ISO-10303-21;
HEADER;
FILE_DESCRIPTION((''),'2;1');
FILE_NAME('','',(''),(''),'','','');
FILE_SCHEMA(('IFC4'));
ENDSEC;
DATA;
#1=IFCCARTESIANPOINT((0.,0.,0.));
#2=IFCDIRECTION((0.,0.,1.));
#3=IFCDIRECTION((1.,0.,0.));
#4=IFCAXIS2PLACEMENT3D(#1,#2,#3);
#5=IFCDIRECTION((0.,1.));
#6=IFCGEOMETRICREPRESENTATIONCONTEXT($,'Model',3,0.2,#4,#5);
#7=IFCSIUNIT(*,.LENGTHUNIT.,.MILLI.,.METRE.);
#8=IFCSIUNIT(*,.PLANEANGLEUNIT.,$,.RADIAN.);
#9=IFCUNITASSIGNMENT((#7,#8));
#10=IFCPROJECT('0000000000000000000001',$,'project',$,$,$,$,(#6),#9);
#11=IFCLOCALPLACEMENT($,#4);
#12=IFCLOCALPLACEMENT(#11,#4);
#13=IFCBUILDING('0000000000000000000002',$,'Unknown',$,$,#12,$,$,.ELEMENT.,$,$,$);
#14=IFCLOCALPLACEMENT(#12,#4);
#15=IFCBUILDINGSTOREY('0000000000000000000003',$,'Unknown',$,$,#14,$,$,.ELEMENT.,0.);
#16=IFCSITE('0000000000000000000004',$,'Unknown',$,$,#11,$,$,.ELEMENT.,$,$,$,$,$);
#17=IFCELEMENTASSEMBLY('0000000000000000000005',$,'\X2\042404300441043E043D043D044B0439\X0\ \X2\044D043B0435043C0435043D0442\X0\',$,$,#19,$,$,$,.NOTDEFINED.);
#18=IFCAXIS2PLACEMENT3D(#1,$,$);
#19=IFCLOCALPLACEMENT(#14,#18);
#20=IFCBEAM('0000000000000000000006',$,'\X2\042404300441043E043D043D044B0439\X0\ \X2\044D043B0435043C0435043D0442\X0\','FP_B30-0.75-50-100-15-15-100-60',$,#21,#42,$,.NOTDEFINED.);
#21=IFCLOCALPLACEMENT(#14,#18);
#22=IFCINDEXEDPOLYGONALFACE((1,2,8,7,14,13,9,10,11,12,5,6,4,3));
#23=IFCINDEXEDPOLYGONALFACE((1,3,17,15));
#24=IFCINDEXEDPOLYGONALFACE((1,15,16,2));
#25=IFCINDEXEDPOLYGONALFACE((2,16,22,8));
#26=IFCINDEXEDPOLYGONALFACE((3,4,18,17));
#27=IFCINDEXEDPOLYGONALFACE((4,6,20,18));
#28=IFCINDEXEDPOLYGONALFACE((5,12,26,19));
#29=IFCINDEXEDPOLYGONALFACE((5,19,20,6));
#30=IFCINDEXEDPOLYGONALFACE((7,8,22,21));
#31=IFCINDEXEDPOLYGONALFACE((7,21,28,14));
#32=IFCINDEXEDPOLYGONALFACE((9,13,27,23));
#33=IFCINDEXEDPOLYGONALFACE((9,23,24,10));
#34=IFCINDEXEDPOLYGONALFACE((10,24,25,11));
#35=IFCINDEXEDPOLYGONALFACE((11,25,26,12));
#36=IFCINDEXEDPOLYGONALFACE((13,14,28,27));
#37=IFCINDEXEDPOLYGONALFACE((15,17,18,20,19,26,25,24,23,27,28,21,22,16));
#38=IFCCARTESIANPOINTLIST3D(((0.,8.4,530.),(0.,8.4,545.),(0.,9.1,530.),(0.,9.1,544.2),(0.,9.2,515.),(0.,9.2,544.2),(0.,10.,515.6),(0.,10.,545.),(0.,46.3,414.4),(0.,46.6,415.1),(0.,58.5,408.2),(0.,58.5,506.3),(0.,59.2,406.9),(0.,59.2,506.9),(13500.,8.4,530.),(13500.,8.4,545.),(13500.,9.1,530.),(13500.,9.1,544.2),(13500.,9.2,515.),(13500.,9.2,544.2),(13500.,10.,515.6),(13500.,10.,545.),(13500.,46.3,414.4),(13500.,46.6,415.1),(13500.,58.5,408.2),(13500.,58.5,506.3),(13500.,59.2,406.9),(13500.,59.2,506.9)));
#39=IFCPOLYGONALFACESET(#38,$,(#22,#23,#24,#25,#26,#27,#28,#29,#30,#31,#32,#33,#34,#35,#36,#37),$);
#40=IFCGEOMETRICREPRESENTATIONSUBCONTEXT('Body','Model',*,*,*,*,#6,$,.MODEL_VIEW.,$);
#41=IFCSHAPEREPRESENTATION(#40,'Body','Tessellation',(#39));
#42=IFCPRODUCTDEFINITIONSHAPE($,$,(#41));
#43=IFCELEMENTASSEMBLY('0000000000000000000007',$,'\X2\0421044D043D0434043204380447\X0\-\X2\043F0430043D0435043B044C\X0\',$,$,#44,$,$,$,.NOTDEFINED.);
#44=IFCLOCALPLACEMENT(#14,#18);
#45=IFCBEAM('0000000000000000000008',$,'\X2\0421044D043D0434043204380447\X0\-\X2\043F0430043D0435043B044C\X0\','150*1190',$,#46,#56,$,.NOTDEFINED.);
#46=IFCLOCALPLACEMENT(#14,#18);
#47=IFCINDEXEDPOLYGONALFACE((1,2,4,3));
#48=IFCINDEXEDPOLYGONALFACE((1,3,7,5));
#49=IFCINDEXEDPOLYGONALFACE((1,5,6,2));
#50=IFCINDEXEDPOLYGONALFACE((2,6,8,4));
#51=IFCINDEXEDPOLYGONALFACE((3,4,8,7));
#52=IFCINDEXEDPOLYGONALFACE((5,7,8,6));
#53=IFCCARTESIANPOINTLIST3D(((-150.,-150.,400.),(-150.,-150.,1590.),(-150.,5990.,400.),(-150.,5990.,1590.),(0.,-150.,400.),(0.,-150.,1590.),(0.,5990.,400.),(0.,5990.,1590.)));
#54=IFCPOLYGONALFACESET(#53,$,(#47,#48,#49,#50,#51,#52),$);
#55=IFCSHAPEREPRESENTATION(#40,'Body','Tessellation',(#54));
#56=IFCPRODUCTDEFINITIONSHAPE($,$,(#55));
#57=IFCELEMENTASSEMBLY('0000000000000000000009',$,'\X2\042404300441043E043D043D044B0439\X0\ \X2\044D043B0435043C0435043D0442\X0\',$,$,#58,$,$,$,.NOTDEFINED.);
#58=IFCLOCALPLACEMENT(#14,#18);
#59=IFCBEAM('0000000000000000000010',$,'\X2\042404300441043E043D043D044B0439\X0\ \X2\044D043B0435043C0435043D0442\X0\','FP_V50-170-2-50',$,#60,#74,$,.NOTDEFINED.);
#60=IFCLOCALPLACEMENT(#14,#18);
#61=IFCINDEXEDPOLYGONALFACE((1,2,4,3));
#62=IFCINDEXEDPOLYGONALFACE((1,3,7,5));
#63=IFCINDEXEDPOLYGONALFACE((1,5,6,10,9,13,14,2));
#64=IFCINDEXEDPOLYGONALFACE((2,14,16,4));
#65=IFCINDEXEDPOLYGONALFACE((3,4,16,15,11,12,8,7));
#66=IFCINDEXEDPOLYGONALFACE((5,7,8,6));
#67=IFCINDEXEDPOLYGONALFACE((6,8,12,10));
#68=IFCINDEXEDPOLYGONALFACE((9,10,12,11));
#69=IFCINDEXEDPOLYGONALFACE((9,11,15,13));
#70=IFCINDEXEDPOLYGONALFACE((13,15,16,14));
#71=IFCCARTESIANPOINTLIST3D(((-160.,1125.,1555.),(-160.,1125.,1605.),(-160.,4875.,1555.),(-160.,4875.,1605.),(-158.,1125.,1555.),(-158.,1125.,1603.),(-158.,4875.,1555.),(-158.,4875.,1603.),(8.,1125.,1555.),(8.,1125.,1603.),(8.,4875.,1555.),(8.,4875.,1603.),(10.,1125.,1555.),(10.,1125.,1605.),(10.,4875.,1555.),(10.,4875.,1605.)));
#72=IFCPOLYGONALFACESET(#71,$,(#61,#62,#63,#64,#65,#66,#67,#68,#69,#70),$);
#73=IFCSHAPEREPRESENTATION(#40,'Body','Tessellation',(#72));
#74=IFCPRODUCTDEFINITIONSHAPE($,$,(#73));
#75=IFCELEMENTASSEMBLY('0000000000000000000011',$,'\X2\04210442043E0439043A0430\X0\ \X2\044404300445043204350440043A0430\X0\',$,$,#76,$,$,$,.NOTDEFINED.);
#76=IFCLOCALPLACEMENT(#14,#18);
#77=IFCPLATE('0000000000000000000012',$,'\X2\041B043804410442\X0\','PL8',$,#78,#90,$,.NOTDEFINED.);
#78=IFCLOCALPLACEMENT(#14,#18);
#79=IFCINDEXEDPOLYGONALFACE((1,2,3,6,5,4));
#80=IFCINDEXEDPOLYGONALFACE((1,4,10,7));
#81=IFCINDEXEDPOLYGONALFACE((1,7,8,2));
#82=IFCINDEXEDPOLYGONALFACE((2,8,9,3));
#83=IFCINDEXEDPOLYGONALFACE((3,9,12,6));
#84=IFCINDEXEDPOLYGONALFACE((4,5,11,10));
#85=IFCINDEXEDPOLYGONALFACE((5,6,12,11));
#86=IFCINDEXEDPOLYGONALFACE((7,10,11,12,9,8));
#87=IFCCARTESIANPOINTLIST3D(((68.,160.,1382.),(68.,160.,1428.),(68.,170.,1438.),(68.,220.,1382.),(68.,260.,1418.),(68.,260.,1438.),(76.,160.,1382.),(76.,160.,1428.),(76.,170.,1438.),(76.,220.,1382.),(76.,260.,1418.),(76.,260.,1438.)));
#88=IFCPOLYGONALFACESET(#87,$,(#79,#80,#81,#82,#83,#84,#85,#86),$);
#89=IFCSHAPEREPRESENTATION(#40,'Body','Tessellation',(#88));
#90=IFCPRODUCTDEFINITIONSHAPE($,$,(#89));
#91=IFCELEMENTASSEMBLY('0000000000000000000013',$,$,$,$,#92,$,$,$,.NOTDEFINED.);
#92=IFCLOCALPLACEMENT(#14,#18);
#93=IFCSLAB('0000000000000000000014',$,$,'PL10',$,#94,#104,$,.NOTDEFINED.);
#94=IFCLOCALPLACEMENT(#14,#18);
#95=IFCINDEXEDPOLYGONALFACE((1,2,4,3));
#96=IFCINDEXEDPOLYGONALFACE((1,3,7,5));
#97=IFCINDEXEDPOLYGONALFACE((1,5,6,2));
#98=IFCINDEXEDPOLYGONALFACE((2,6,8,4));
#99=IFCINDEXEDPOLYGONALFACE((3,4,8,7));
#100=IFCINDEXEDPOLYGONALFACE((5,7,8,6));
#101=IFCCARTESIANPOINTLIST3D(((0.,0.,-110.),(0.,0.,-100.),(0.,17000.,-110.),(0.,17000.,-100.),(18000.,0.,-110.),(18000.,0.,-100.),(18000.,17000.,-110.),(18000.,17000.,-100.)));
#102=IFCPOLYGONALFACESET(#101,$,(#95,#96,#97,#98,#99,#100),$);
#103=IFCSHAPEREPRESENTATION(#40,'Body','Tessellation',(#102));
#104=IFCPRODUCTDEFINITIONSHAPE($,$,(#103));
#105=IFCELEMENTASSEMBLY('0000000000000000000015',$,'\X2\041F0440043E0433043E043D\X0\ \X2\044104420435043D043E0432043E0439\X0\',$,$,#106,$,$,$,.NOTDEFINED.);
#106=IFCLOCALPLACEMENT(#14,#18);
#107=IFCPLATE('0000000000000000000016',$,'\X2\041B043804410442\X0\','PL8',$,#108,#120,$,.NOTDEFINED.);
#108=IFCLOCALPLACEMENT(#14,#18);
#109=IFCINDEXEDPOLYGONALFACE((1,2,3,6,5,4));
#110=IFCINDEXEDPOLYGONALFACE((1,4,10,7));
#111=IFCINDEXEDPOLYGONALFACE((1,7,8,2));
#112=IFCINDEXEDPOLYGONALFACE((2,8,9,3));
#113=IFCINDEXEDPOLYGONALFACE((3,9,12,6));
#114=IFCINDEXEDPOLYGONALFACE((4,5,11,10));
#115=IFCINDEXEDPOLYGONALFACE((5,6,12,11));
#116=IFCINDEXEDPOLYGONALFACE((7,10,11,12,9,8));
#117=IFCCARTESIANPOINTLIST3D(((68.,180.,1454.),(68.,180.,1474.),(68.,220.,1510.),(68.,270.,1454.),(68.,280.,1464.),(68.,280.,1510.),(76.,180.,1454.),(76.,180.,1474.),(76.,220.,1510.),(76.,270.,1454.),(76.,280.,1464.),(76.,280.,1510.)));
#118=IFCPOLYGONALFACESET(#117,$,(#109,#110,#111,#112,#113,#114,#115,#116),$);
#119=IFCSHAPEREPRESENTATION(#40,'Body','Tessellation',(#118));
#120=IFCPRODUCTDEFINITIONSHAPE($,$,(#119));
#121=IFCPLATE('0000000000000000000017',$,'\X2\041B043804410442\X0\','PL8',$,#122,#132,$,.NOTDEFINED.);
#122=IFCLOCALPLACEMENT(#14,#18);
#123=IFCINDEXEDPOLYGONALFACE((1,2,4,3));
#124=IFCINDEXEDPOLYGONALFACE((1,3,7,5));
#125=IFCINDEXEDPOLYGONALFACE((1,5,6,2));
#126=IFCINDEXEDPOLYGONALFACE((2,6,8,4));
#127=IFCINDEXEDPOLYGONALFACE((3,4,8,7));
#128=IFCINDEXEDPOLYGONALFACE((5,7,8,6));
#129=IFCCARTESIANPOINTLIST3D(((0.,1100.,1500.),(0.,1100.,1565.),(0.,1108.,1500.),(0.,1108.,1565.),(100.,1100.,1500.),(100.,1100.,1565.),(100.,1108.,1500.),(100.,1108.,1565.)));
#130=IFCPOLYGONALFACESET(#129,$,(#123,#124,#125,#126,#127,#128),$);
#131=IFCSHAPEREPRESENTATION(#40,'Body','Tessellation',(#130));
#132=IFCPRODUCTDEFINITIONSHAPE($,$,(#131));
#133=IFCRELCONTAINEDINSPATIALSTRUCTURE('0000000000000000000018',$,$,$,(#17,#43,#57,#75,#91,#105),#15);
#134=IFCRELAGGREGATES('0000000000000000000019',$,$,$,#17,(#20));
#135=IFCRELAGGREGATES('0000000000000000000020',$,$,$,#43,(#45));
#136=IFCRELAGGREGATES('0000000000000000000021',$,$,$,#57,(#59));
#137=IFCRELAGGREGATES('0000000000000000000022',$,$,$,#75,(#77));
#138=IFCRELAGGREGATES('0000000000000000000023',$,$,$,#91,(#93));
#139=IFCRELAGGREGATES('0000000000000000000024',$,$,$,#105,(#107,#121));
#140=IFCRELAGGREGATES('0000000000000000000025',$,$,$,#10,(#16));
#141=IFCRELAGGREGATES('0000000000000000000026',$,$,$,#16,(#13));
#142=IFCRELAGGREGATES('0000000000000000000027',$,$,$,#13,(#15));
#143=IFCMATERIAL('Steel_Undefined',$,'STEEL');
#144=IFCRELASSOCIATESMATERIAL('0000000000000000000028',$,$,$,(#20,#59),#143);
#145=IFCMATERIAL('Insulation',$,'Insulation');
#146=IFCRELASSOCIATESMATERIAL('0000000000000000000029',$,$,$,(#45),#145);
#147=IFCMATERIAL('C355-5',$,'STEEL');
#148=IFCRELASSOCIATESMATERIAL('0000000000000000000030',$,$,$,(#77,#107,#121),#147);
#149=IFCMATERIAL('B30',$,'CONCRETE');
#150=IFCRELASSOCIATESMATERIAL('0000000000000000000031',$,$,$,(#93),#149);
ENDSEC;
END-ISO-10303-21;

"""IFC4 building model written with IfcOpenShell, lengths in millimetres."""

from ifc_helpers import new_model, si_unit, direction, frame, origin_with_axes, place, context, subcontext, project, spatial, line, indexed_curve, outline, extrude, material, element, aggregate, save


model = new_model("IFC4")

# Units and contexts
model_context = context("Model", 3, precision=0.2, world=origin_with_axes(), true_north=direction((0.0, 1.0)))
body_context = subcontext(model_context, "Body", "Model", "MODEL_VIEW")
ifc_project = project(units=[si_unit("LENGTHUNIT", "METRE", prefix="MILLI"), si_unit("PLANEANGLEUNIT", "RADIAN")], contexts=[model_context])

# Site, building, storey
site_placement = place(None, origin_with_axes())
site = spatial("IfcSite", under=ifc_project, at=site_placement, Name="Unknown", CompositionType="ELEMENT")
building_placement = place(site_placement, origin_with_axes())
building = spatial("IfcBuilding", under=site, at=building_placement, Name="Unknown", CompositionType="ELEMENT")
storey_placement = place(building_placement, origin_with_axes())
storey = spatial("IfcBuildingStorey", under=building, at=storey_placement, Name="Unknown", CompositionType="ELEMENT", Elevation=0.0)

# Shared definitions
ifc_material_1 = material(Name="Steel_Undefined", Category="STEEL")

# Shared definitions
ifc_material_2 = material(Name="C355-5", Category="STEEL")

# Element assemblies, beams
ifc_material_3 = material(Name="Insulation", Category="Insulation")
assembly_1_placement = place(storey_placement, frame((0.0, 9.6, 530.0), z_axis=(0.0, -1.0, 0.0), x_axis=(1.0, 0.0, 0.0)))
assembly_1 = element("IfcElementAssembly", 1, at=assembly_1_placement, inside=storey, Name="Фасонный элемент", PredefinedType="NOTDEFINED")
beam_1_placement = place(assembly_1_placement, origin_with_axes())
beam_1 = element("IfcBeam", 2, at=beam_1_placement, material=ifc_material_1, Name="Фасонный элемент", Description="FP_B30-0.75-50-100-15-15-100-60", PredefinedType="NOTDEFINED", context=body_context, shape_type="SolidModel", body=[
    extrude(outline(indexed_curve([(0.4, -15.0), (0.4, 14.2), (0.5, 14.2), (0.5, 0.0), (1.2, 0.0), (1.2, 15.0), (-0.4, 15.0), (-0.4, -14.4), (-49.6, -23.1), (-49.6, -123.1), (-36.6, -115.6), (-37.0, -114.9), (-48.9, -121.8), (-48.9, -23.7)], segments=[line(1, 2, 3, 4, 5, 6, 7, 8, 9, 10, 11, 12, 13, 14, 1)])), frame((0.0, 0.0, 0.0), z_axis=(-1.0, 0.0, 0.0), x_axis=(0.0, 0.0, 1.0)), (0.0, 0.0, -1.0), 13500.0),
])
aggregate(assembly_1, [beam_1])
assembly_2_placement = place(storey_placement, frame((-75.0, -150.0, 995.0), z_axis=(0.0, 0.0, -1.0), x_axis=(0.0, 1.0, 0.0)))
assembly_2 = element("IfcElementAssembly", 3, at=assembly_2_placement, inside=storey, Name="Сэндвич-панель", PredefinedType="NOTDEFINED")
beam_2_placement = place(assembly_2_placement, origin_with_axes())
beam_2 = element("IfcBeam", 4, at=beam_2_placement, material=ifc_material_3, Name="Сэндвич-панель", Description="150*1190", PredefinedType="NOTDEFINED", context=body_context, shape_type="SolidModel", body=[
    extrude(outline(indexed_curve([(-595.0, -75.0), (595.0, -75.0), (595.0, 75.0), (-595.0, 75.0)], segments=[line(1, 2, 3, 4, 1)])), frame((0.0, 0.0, 0.0), z_axis=(-1.0, 0.0, 0.0), x_axis=(0.0, 0.0, 1.0)), (0.0, 0.0, -1.0), 6140.0),
])
aggregate(assembly_2, [beam_2])
assembly_3_placement = place(storey_placement, frame((-75.0, 1125.0, 1580.0), z_axis=(1.0, 0.0, 0.0), x_axis=(0.0, 1.0, 0.0)))
assembly_3 = element("IfcElementAssembly", 5, at=assembly_3_placement, inside=storey, Name="Фасонный элемент", PredefinedType="NOTDEFINED")
beam_3_placement = place(assembly_3_placement, origin_with_axes())
beam_3 = element("IfcBeam", 6, at=beam_3_placement, material=ifc_material_1, Name="Фасонный элемент", Description="FP_V50-170-2-50", PredefinedType="NOTDEFINED", context=body_context, shape_type="SolidModel", body=[
    extrude(outline(indexed_curve([(-85.0, -25.0), (-83.0, -25.0), (-83.0, 23.0), (83.0, 23.0), (83.0, -25.0), (85.0, -25.0), (85.0, 25.0), (-85.0, 25.0)], segments=[line(1, 2, 3, 4, 5, 6, 7, 8, 1)])), frame((0.0, 0.0, 0.0), z_axis=(-1.0, 0.0, 0.0), x_axis=(0.0, 0.0, 1.0)), (0.0, 0.0, -1.0), 3750.0),
])
aggregate(assembly_3, [beam_3])

# Element assembly, plate
assembly_4_placement = place(storey_placement, frame((80.0, 80.0, -200.0), z_axis=(0.0, -1.0, 0.0), x_axis=(0.0, 0.0, 1.0)))
assembly_4 = element("IfcElementAssembly", 7, at=assembly_4_placement, inside=storey, Name="Стойка фахверка", PredefinedType="NOTDEFINED")
plate_1_placement = place(assembly_4_placement, frame((1638.0, 8.0, -90.0), z_axis=(0.0, 1.0, 0.0), x_axis=(0.0, 0.0, -1.0)))
plate_1 = element("IfcPlate", 8, at=plate_1_placement, material=ifc_material_2, Name="Лист", Description="PL8", PredefinedType="NOTDEFINED", context=body_context, shape_type="SolidModel", body=[
    extrude(outline(indexed_curve([(0.0, 0.0), (90.0, 0.0), (90.0, 20.0), (50.0, 56.0), (-10.0, 56.0), (-10.0, 10.0)], segments=[line(1, 2, 3, 4, 5, 6, 1)])), frame((0.0, 0.0, 4.0), z_axis=(0.0, 0.0, 1.0), x_axis=(1.0, 0.0, 0.0)), (0.0, 0.0, -1.0), 8.0),
])
aggregate(assembly_4, [plate_1])

# Element assembly, slab
assembly_5_placement = place(storey_placement, frame((0.0, 0.0, -105.0), z_axis=(0.0, 0.0, 1.0), x_axis=(1.0, 0.0, 0.0)))
assembly_5 = element("IfcElementAssembly", 9, at=assembly_5_placement, inside=storey, PredefinedType="NOTDEFINED")
ifc_material_4 = material(Name="B30", Category="CONCRETE")
slab_placement = place(assembly_5_placement, origin_with_axes())
slab = element("IfcSlab", 10, at=slab_placement, material=ifc_material_4, Description="PL10", PredefinedType="NOTDEFINED", context=body_context, shape_type="SolidModel", body=[
    extrude(outline(indexed_curve([(0.0, 0.0), (18000.0, 0.0), (18000.0, 17000.0), (0.0, 17000.0)], segments=[line(1, 2, 3, 4, 1)])), frame((0.0, 0.0, 5.0), z_axis=(0.0, 0.0, 1.0), x_axis=(1.0, 0.0, 0.0)), (0.0, 0.0, -1.0), 10.0),
])
aggregate(assembly_5, [slab])

# Element assembly, plates
assembly_6_placement = place(storey_placement, frame((50.0, 6000.0, 1450.0), z_axis=(0.0, 0.0, -1.0), x_axis=(0.0, -1.0, 0.0)))
assembly_6 = element("IfcElementAssembly", 11, at=assembly_6_placement, inside=storey, Name="Прогон стеновой", PredefinedType="NOTDEFINED")
plate_2_placement = place(assembly_6_placement, frame((5820.0, -22.0, -60.0), z_axis=(0.0, -1.0, 0.0), x_axis=(0.0, 0.0, 1.0)))
plate_2 = element("IfcPlate", 12, at=plate_2_placement, material=ifc_material_2, Name="Лист", Description="PL8", PredefinedType="NOTDEFINED", context=body_context, shape_type="SolidModel", body=[
    extrude(outline(indexed_curve([(0.0, 40.0), (36.0, 0.0), (56.0, 0.0), (56.0, 90.0), (46.0, 100.0), (0.0, 100.0)], segments=[line(1, 2, 3, 4, 5, 6, 1)])), frame((0.0, 0.0, 4.0), z_axis=(0.0, 0.0, 1.0), x_axis=(1.0, 0.0, 0.0)), (0.0, 0.0, -1.0), 8.0),
])
plate_3_placement = place(assembly_6_placement, frame((4896.0, 50.0, -50.0), z_axis=(-1.0, 0.0, 0.0), x_axis=(0.0, 0.0, -1.0)))
plate_3 = element("IfcPlate", 13, at=plate_3_placement, material=ifc_material_2, Name="Лист", Description="PL8", PredefinedType="NOTDEFINED", context=body_context, shape_type="SolidModel", body=[
    extrude(outline(indexed_curve([(0.0, 0.0), (65.0, 0.0), (65.0, 100.0), (0.0, 100.0)], segments=[line(1, 2, 3, 4, 1)])), frame((0.0, 0.0, 4.0), z_axis=(0.0, 0.0, 1.0), x_axis=(1.0, 0.0, 0.0)), (0.0, 0.0, -1.0), 8.0),
])
aggregate(assembly_6, [plate_2, plate_3])

save(model, "model.ifc")
